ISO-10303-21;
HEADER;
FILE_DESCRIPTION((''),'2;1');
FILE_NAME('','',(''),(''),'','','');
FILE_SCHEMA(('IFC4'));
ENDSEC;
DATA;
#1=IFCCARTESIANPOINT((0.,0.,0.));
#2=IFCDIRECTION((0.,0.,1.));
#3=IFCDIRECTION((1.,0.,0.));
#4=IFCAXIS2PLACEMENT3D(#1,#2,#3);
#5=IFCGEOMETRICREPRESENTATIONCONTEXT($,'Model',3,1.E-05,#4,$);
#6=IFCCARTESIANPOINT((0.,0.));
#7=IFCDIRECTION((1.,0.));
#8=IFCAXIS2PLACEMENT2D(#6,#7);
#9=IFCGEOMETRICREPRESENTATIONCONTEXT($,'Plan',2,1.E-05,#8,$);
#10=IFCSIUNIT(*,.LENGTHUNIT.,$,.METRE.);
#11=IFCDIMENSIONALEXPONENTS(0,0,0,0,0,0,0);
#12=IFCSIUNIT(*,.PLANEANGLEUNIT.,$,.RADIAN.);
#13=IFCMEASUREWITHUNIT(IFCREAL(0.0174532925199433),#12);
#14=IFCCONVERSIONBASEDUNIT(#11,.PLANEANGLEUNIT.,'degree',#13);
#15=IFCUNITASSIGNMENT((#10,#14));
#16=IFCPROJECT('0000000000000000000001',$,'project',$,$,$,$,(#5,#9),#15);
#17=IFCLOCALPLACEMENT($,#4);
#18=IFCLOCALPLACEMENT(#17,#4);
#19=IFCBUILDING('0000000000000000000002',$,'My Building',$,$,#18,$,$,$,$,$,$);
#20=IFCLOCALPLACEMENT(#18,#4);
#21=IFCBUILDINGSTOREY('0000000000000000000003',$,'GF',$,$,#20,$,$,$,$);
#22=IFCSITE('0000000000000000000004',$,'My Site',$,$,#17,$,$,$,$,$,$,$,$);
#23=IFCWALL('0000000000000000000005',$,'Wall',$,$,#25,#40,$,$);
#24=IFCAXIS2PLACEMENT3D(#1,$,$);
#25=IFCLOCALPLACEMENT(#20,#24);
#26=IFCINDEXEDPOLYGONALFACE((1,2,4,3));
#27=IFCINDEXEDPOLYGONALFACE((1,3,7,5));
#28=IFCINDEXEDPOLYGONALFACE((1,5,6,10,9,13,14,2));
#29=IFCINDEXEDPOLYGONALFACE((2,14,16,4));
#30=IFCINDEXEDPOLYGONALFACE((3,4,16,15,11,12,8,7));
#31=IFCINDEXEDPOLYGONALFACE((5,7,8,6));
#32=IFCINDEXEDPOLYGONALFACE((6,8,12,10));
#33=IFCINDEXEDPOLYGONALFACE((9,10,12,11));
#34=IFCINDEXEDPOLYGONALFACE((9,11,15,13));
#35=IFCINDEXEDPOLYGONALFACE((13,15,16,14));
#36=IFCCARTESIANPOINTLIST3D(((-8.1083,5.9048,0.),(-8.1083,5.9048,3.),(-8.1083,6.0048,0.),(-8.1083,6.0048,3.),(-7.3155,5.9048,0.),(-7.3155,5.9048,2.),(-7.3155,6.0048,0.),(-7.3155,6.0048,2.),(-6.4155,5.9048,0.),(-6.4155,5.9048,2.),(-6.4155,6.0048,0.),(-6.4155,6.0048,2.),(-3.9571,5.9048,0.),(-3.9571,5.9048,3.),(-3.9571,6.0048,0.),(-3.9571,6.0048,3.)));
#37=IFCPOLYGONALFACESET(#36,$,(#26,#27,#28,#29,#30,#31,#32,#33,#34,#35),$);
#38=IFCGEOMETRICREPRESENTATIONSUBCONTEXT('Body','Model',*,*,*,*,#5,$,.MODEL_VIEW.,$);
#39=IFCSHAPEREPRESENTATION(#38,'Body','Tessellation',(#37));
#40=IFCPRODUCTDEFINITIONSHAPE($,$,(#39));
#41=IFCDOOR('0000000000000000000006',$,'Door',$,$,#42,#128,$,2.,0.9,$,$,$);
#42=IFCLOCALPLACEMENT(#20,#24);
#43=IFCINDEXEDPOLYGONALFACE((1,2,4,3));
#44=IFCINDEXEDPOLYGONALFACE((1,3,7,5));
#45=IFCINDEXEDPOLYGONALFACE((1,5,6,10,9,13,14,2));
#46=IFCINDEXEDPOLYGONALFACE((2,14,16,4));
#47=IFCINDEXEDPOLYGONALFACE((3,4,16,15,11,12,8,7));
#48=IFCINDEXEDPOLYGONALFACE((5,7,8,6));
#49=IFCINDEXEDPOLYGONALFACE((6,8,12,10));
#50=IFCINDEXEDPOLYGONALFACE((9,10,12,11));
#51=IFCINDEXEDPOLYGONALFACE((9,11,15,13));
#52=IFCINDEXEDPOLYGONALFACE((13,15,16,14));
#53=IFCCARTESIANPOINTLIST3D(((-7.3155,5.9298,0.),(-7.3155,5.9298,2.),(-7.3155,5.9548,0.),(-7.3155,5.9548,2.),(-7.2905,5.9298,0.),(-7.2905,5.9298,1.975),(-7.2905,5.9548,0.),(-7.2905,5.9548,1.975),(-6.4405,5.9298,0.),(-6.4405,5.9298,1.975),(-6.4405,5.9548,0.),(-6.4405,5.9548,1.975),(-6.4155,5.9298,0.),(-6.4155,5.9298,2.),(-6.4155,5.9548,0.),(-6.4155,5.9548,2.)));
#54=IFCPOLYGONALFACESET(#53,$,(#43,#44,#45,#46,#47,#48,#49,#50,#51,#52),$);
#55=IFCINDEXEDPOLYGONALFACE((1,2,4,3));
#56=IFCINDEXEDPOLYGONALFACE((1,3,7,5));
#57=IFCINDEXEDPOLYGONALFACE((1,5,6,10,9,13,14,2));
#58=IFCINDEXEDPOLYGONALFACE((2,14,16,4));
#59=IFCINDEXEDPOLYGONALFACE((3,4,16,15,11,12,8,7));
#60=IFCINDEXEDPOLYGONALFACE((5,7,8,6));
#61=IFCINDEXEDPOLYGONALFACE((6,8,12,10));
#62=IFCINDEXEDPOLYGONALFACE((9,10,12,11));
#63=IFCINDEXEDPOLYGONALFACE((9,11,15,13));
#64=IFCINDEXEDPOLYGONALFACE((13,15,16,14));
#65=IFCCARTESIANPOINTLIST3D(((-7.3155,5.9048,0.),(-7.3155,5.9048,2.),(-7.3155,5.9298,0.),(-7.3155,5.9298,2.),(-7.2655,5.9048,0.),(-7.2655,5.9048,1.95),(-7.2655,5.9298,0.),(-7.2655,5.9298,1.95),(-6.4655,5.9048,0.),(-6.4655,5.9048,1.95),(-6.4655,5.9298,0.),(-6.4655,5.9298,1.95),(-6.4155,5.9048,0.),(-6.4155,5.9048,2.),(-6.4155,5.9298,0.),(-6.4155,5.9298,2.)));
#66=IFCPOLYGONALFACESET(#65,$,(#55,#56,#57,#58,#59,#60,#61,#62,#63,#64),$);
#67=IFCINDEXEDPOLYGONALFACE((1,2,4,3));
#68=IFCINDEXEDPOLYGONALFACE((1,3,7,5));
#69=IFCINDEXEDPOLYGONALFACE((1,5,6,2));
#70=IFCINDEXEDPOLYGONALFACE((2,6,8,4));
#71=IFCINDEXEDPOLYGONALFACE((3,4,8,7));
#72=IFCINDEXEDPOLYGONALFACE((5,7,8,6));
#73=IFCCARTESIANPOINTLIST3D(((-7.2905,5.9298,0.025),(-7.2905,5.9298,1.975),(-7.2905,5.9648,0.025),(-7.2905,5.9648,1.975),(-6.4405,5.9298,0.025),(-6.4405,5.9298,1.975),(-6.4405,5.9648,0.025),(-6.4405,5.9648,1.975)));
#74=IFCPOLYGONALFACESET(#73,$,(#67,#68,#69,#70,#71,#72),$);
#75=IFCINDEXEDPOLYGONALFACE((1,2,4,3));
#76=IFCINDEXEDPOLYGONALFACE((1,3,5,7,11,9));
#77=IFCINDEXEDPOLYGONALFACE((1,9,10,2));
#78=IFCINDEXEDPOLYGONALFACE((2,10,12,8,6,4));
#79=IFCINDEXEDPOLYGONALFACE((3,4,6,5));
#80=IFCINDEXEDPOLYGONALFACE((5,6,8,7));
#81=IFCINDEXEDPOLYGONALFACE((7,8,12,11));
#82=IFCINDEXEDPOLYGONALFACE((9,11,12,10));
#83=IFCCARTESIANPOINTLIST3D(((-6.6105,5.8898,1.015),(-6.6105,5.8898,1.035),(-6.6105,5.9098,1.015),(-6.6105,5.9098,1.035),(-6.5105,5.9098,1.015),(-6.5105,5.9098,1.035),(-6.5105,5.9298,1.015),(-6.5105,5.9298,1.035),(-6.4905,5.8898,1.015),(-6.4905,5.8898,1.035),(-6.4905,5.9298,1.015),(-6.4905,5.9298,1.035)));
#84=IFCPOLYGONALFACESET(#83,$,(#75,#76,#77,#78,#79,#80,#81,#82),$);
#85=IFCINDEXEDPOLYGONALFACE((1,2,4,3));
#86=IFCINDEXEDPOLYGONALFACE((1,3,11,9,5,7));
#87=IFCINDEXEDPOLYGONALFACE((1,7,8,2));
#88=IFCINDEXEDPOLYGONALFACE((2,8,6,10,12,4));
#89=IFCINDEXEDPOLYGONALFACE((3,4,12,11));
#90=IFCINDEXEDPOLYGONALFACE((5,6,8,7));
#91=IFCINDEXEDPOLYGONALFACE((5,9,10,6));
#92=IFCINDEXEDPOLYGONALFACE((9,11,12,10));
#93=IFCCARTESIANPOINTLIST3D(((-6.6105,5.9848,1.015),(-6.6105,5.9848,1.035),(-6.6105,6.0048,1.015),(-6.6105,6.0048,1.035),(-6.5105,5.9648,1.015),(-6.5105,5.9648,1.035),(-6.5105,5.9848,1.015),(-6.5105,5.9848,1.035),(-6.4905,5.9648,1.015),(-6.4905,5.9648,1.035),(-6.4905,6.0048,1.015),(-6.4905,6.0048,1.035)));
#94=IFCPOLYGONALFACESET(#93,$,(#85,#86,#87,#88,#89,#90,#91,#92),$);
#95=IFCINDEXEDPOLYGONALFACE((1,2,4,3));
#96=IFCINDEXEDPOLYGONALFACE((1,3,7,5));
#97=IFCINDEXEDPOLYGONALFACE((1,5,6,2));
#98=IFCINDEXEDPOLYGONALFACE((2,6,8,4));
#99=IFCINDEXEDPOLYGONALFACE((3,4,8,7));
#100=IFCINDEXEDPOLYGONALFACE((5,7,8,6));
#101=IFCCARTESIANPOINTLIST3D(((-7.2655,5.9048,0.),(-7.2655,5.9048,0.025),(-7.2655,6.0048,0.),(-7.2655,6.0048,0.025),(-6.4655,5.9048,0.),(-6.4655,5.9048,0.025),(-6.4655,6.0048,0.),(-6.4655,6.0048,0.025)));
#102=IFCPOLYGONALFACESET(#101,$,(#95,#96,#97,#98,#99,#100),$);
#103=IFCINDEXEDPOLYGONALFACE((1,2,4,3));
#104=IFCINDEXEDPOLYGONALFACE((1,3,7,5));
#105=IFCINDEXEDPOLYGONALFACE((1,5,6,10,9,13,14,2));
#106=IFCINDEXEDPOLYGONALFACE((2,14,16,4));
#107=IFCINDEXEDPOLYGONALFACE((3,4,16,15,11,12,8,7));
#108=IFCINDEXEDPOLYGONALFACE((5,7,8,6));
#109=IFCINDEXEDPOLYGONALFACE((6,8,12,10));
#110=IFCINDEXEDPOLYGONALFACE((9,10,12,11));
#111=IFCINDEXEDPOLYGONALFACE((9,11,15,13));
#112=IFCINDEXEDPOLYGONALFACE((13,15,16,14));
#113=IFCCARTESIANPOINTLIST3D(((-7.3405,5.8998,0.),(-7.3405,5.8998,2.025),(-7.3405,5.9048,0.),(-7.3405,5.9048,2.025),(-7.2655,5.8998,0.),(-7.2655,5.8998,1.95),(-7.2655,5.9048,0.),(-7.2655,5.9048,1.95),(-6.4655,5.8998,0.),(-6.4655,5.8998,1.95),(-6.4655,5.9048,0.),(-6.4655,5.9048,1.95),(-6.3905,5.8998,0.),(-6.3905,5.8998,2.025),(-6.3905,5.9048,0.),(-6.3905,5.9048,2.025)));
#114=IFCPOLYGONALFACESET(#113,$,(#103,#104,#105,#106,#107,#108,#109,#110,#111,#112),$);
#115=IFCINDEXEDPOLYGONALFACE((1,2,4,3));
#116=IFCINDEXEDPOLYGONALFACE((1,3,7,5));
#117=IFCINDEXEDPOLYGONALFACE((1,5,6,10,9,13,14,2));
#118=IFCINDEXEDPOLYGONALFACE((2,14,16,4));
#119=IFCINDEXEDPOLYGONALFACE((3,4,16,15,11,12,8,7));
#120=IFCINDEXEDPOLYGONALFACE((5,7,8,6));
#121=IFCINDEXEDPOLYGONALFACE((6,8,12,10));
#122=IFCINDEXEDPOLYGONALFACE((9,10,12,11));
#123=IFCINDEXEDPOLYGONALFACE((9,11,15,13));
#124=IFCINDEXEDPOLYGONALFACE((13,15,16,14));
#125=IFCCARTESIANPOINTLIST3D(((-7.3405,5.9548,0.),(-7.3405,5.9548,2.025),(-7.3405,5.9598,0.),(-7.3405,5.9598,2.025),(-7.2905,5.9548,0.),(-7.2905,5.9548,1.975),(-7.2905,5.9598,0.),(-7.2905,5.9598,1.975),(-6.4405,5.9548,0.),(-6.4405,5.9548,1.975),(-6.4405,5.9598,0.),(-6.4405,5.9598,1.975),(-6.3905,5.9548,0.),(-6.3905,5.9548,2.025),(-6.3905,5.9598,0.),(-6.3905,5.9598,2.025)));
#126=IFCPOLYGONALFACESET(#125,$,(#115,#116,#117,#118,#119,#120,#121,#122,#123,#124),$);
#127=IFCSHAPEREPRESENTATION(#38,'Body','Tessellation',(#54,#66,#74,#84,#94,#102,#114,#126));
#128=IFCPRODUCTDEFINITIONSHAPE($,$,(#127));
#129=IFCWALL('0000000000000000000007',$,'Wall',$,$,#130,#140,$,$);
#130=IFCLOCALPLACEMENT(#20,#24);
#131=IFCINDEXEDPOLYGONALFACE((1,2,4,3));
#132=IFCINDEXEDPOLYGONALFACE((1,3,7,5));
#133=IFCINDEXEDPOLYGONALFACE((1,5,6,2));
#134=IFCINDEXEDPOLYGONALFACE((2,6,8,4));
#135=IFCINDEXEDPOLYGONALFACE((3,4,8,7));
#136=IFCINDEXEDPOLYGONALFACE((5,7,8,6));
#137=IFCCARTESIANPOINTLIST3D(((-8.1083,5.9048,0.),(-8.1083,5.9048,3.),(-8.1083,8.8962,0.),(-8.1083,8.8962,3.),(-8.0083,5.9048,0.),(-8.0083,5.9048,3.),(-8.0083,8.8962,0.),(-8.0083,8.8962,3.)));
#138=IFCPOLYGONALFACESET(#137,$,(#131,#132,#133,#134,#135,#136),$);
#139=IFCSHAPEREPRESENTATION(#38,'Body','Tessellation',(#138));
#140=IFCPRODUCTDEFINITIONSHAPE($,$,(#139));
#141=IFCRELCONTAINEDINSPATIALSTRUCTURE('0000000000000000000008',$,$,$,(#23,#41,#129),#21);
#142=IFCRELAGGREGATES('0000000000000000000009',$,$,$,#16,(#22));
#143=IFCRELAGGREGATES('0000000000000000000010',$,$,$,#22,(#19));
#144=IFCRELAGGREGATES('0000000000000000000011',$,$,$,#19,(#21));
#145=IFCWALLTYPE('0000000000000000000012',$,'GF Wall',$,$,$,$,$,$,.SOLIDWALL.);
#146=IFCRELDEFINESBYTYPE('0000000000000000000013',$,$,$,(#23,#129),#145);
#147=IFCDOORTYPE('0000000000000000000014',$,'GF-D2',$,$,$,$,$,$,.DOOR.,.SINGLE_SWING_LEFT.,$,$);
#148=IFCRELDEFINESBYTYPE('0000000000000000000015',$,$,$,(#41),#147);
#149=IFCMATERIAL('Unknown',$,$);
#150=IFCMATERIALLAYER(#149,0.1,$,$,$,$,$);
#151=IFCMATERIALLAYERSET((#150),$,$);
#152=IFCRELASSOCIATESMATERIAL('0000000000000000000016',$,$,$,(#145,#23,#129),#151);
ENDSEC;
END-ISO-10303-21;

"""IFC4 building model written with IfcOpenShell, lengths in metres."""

from ifc_helpers import new_model, entity, si_unit, converted_unit, frame, origin_with_axes, origin_2d_with_axis, place, context, subcontext, project, spatial, line, indexed_curve, outline, extrude, shape, source, transform, mapped, material, layer, layer_set, layer_usage, type_object, type_shapes, element, fill, save


model = new_model("IFC4")

# Units and contexts
model_context = context("Model", 3, precision=1e-05, world=origin_with_axes())
plan_context = context("Plan", 2, precision=1e-05, world=origin_2d_with_axis())
body_context_1 = subcontext(model_context, "Body", "Model", "MODEL_VIEW")
body_context_2 = subcontext(plan_context, "Body", "Plan", "PLAN_VIEW")
ifc_project = project(units=[si_unit("LENGTHUNIT", "METRE"), converted_unit("PLANEANGLEUNIT", "degree", entity("IfcReal", 0.0174532925199433), si_unit("PLANEANGLEUNIT", "RADIAN"), dimensions=[0, 0, 0, 0, 0, 0, 0])], contexts=[model_context, plan_context])

# Site, building, storey
site_placement = place(None, origin_with_axes())
site = spatial("IfcSite", under=ifc_project, at=site_placement, Name="My Site")
building_placement = place(site_placement, origin_with_axes())
building = spatial("IfcBuilding", under=site, at=building_placement, Name="My Building")
storey_placement = place(building_placement, origin_with_axes())
storey = spatial("IfcBuildingStorey", under=building, at=storey_placement, Name="GF")

# Shared definitions
ifc_material = material(Name="Unknown")

# Shared definitions
ifc_layer = layer(ifc_material, 0.1)
ifc_layer_set = layer_set([ifc_layer])
wall_type = type_object("IfcWallType", Name="GF Wall", PredefinedType="SOLIDWALL", material=ifc_layer_set)

# Wall, opening, door
ifc_layer_usage_1 = layer_usage(ifc_layer_set, "AXIS2", "POSITIVE", 0.0)
wall_1_placement = place(storey_placement, frame((-8.1083, 5.9048, 0.0), z_axis=(0.0, 0.0, 1.0), x_axis=(1.0, 0.0, 0.0)))
wall_1 = element("IfcWall", 1, at=wall_1_placement, inside=storey, type_object=wall_type, material=ifc_layer_usage_1, Name="Wall", context=body_context_1, shape_type="SweptSolid", body=[
    extrude(outline(indexed_curve([(0.0, 0.0), (0.0, 0.1), (4.1512, 0.1), (4.1512, 0.0)], segments=[line(1, 2, 3, 4, 1)])), origin_with_axes(), (0.0, 0.0, 1.0), 3.0),
])
shared_shape_1 = source(origin_with_axes(), body_context_1, "Body", "SweptSolid", [
    extrude(outline(indexed_curve([(0.0, 0.0), (0.9, 0.0), (0.9, 2.0), (0.0, 2.0)], segments=[line(1, 2, 3, 4, 1)])), frame((0.0, -0.6, 0.0), z_axis=(0.0, -1.0, 0.0), x_axis=(1.0, 0.0, 0.0)), (0.0, 0.0, -1.0), 1.2),
])
opening_1_placement = place(wall_1_placement, frame((0.7928, 0.0, 0.0), z_axis=(0.0, 0.0, 1.0), x_axis=(1.0, 0.0, 0.0)))
opening_1 = element("IfcOpeningElement", 2, at=opening_1_placement, cuts=wall_1, PredefinedType="OPENING", context=body_context_1, shape_type="MappedRepresentation", body=[
    mapped(shared_shape_1, transform((0.0, 0.0, 0.0), x_axis=(1.0, 0.0, 0.0), y_axis=(0.0, 1.0, 0.0), z_axis=(0.0, 0.0, 1.0), scale=1.0)),
])
door_type_1 = type_object("IfcDoorType", Name="GF-D2", OperationType="SINGLE_SWING_LEFT", PredefinedType="DOOR")
shared_shape_2 = source(origin_with_axes(), body_context_1, "Body", "SweptSolid", [
    extrude(outline(indexed_curve([(0.0, 0.0), (0.0, 2.0), (0.9, 2.0), (0.9, 0.0), (0.875, 0.0), (0.875, 1.975), (0.025, 1.975), (0.025, 0.0)], segments=[line(1, 2, 3, 4, 5, 6, 7, 8, 1)])), frame((0.0, 0.025, 0.0), z_axis=(0.0, -1.0, 0.0), x_axis=(1.0, 0.0, 0.0)), (0.0, 0.0, -1.0), 0.025),
    extrude(outline(indexed_curve([(0.0, 0.0), (0.0, 2.0), (0.9, 2.0), (0.9, 0.0), (0.85, 0.0), (0.85, 1.95), (0.05, 1.95), (0.05, 0.0)], segments=[line(1, 2, 3, 4, 5, 6, 7, 8, 1)])), frame((0.0, 0.0, 0.0), z_axis=(0.0, -1.0, 0.0), x_axis=(1.0, 0.0, 0.0)), (0.0, 0.0, -1.0), 0.025),
    extrude(outline(indexed_curve([(0.0, 0.0), (0.85, 0.0), (0.85, 0.035), (0.0, 0.035)], segments=[line(1, 2, 3, 4, 1)])), frame((0.025, 0.025, 0.025), z_axis=(0.0, 0.0, 1.0), x_axis=(1.0, 0.0, 0.0)), (0.0, 0.0, 1.0), 1.95),
    extrude(outline(indexed_curve([(0.0, 0.0), (0.0, -0.04), (-0.12, -0.04), (-0.12, -0.02), (-0.02, -0.02), (-0.02, 0.0)], segments=[line(1, 2, 3, 4, 5, 6, 1)])), frame((0.825, 0.025, 1.015), z_axis=(0.0, 0.0, 1.0), x_axis=(1.0, 0.0, 0.0)), (0.0, 0.0, 1.0), 0.02),
    extrude(outline(indexed_curve([(0.0, 0.0), (0.0, 0.04), (-0.12, 0.04), (-0.12, 0.02), (-0.02, 0.02), (-0.02, 0.0)], segments=[line(1, 2, 3, 4, 5, 6, 1)])), frame((0.825, 0.06, 1.015), z_axis=(0.0, 0.0, 1.0), x_axis=(1.0, 0.0, 0.0)), (0.0, 0.0, 1.0), 0.02),
    extrude(outline(indexed_curve([(0.0, 0.0), (0.8, 0.0), (0.8, 0.1), (0.0, 0.1)], segments=[line(1, 2, 3, 4, 1)])), frame((0.05, 0.0, 0.0), z_axis=(0.0, 0.0, 1.0), x_axis=(1.0, 0.0, 0.0)), (0.0, 0.0, 1.0), 0.025),
    extrude(outline(indexed_curve([(0.0, 0.0), (0.0, 2.025), (0.95, 2.025), (0.95, 0.0), (0.875, 0.0), (0.875, 1.95), (0.075, 1.95), (0.075, 0.0)], segments=[line(1, 2, 3, 4, 5, 6, 7, 8, 1)])), frame((-0.025, -0.005, 0.0), z_axis=(0.0, -1.0, 0.0), x_axis=(1.0, 0.0, 0.0)), (0.0, 0.0, -1.0), 0.005),
    extrude(outline(indexed_curve([(0.0, 0.0), (0.0, 2.025), (0.95, 2.025), (0.95, 0.0), (0.9, 0.0), (0.9, 1.975), (0.05, 1.975), (0.05, 0.0)], segments=[line(1, 2, 3, 4, 5, 6, 7, 8, 1)])), frame((-0.025, 0.05, 0.0), z_axis=(0.0, -1.0, 0.0), x_axis=(1.0, 0.0, 0.0)), (0.0, 0.0, -1.0), 0.005),
])
shared_shape_3 = source(origin_with_axes(), body_context_2, "Body", "Curve2D", [
    entity("IfcIndexedPolyCurve", entity("IfcCartesianPointList2D", [[0.0, 0.0], [0.0, 0.05], [0.025, 0.05], [0.025, 0.025], [0.05, 0.025], [0.05, 0.0]]), [entity("IfcLineIndex", [1, 2, 3, 4, 5, 6, 1])]),
    entity("IfcIndexedPolyCurve", entity("IfcCartesianPointList2D", [[0.9, 0.0], [0.9, 0.05], [0.875, 0.05], [0.875, 0.025], [0.85, 0.025], [0.85, 0.0]]), [entity("IfcLineIndex", [1, 2, 3, 4, 5, 6, 1])]),
    entity("IfcTrimmedCurve", entity("IfcEllipse", entity("IfcAxis2Placement2D", entity("IfcCartesianPoint", [0.06, 0.05]), entity("IfcDirection", [1.0, 0.0])), 0.815, 0.85), [entity("IfcCartesianPoint", [0.875, 0.05])], [entity("IfcCartesianPoint", [0.06, 0.9])], True, "CARTESIAN"),
    entity("IfcIndexedPolyCurve", entity("IfcCartesianPointList2D", [[0.025, 0.05], [0.06, 0.05], [0.06, 0.9], [0.025, 0.9]]), [entity("IfcLineIndex", [1, 2, 3, 4, 1])]),
])
type_shapes(door_type_1, [shared_shape_2, shared_shape_3])
door_1_placement = place(opening_1_placement, origin_with_axes())
door_1 = element("IfcDoor", 3, at=door_1_placement, inside=storey, type_object=door_type_1, Name="Door", OverallHeight=2.0, OverallWidth=0.9, shapes=[
    shape(body_context_1, "Body", "MappedRepresentation", [mapped(shared_shape_2, transform((0.0, 0.0, 0.0), x_axis=(1.0, 0.0, 0.0), y_axis=(0.0, 1.0, 0.0), z_axis=(0.0, 0.0, 1.0), scale=1.0))]),
    shape(body_context_2, "Body", "MappedRepresentation", [mapped(shared_shape_3, transform((0.0, 0.0, 0.0), x_axis=(1.0, 0.0, 0.0), y_axis=(0.0, 1.0, 0.0), z_axis=(0.0, 0.0, 1.0), scale=1.0))]),
])
fill(opening_1, door_1)

# Wall
ifc_layer_usage_2 = layer_usage(ifc_layer_set, "AXIS2", "POSITIVE", 0.0)
wall_2_placement = place(storey_placement, frame((-8.1083, 8.8962, 0.0), z_axis=(0.0, 0.0, 1.0), x_axis=(0.0, -1.0, 0.0)))
element("IfcWall", 4, at=wall_2_placement, inside=storey, type_object=wall_type, material=ifc_layer_usage_2, Name="Wall", context=body_context_1, shape_type="SweptSolid", body=[
    extrude(outline(indexed_curve([(0.0, 0.0), (0.0, 0.1), (2.9914, 0.1), (2.9914, 0.0)], segments=[line(1, 2, 3, 4, 1)])), origin_with_axes(), (0.0, 0.0, 1.0), 3.0),
])

save(model, "model.ifc")
